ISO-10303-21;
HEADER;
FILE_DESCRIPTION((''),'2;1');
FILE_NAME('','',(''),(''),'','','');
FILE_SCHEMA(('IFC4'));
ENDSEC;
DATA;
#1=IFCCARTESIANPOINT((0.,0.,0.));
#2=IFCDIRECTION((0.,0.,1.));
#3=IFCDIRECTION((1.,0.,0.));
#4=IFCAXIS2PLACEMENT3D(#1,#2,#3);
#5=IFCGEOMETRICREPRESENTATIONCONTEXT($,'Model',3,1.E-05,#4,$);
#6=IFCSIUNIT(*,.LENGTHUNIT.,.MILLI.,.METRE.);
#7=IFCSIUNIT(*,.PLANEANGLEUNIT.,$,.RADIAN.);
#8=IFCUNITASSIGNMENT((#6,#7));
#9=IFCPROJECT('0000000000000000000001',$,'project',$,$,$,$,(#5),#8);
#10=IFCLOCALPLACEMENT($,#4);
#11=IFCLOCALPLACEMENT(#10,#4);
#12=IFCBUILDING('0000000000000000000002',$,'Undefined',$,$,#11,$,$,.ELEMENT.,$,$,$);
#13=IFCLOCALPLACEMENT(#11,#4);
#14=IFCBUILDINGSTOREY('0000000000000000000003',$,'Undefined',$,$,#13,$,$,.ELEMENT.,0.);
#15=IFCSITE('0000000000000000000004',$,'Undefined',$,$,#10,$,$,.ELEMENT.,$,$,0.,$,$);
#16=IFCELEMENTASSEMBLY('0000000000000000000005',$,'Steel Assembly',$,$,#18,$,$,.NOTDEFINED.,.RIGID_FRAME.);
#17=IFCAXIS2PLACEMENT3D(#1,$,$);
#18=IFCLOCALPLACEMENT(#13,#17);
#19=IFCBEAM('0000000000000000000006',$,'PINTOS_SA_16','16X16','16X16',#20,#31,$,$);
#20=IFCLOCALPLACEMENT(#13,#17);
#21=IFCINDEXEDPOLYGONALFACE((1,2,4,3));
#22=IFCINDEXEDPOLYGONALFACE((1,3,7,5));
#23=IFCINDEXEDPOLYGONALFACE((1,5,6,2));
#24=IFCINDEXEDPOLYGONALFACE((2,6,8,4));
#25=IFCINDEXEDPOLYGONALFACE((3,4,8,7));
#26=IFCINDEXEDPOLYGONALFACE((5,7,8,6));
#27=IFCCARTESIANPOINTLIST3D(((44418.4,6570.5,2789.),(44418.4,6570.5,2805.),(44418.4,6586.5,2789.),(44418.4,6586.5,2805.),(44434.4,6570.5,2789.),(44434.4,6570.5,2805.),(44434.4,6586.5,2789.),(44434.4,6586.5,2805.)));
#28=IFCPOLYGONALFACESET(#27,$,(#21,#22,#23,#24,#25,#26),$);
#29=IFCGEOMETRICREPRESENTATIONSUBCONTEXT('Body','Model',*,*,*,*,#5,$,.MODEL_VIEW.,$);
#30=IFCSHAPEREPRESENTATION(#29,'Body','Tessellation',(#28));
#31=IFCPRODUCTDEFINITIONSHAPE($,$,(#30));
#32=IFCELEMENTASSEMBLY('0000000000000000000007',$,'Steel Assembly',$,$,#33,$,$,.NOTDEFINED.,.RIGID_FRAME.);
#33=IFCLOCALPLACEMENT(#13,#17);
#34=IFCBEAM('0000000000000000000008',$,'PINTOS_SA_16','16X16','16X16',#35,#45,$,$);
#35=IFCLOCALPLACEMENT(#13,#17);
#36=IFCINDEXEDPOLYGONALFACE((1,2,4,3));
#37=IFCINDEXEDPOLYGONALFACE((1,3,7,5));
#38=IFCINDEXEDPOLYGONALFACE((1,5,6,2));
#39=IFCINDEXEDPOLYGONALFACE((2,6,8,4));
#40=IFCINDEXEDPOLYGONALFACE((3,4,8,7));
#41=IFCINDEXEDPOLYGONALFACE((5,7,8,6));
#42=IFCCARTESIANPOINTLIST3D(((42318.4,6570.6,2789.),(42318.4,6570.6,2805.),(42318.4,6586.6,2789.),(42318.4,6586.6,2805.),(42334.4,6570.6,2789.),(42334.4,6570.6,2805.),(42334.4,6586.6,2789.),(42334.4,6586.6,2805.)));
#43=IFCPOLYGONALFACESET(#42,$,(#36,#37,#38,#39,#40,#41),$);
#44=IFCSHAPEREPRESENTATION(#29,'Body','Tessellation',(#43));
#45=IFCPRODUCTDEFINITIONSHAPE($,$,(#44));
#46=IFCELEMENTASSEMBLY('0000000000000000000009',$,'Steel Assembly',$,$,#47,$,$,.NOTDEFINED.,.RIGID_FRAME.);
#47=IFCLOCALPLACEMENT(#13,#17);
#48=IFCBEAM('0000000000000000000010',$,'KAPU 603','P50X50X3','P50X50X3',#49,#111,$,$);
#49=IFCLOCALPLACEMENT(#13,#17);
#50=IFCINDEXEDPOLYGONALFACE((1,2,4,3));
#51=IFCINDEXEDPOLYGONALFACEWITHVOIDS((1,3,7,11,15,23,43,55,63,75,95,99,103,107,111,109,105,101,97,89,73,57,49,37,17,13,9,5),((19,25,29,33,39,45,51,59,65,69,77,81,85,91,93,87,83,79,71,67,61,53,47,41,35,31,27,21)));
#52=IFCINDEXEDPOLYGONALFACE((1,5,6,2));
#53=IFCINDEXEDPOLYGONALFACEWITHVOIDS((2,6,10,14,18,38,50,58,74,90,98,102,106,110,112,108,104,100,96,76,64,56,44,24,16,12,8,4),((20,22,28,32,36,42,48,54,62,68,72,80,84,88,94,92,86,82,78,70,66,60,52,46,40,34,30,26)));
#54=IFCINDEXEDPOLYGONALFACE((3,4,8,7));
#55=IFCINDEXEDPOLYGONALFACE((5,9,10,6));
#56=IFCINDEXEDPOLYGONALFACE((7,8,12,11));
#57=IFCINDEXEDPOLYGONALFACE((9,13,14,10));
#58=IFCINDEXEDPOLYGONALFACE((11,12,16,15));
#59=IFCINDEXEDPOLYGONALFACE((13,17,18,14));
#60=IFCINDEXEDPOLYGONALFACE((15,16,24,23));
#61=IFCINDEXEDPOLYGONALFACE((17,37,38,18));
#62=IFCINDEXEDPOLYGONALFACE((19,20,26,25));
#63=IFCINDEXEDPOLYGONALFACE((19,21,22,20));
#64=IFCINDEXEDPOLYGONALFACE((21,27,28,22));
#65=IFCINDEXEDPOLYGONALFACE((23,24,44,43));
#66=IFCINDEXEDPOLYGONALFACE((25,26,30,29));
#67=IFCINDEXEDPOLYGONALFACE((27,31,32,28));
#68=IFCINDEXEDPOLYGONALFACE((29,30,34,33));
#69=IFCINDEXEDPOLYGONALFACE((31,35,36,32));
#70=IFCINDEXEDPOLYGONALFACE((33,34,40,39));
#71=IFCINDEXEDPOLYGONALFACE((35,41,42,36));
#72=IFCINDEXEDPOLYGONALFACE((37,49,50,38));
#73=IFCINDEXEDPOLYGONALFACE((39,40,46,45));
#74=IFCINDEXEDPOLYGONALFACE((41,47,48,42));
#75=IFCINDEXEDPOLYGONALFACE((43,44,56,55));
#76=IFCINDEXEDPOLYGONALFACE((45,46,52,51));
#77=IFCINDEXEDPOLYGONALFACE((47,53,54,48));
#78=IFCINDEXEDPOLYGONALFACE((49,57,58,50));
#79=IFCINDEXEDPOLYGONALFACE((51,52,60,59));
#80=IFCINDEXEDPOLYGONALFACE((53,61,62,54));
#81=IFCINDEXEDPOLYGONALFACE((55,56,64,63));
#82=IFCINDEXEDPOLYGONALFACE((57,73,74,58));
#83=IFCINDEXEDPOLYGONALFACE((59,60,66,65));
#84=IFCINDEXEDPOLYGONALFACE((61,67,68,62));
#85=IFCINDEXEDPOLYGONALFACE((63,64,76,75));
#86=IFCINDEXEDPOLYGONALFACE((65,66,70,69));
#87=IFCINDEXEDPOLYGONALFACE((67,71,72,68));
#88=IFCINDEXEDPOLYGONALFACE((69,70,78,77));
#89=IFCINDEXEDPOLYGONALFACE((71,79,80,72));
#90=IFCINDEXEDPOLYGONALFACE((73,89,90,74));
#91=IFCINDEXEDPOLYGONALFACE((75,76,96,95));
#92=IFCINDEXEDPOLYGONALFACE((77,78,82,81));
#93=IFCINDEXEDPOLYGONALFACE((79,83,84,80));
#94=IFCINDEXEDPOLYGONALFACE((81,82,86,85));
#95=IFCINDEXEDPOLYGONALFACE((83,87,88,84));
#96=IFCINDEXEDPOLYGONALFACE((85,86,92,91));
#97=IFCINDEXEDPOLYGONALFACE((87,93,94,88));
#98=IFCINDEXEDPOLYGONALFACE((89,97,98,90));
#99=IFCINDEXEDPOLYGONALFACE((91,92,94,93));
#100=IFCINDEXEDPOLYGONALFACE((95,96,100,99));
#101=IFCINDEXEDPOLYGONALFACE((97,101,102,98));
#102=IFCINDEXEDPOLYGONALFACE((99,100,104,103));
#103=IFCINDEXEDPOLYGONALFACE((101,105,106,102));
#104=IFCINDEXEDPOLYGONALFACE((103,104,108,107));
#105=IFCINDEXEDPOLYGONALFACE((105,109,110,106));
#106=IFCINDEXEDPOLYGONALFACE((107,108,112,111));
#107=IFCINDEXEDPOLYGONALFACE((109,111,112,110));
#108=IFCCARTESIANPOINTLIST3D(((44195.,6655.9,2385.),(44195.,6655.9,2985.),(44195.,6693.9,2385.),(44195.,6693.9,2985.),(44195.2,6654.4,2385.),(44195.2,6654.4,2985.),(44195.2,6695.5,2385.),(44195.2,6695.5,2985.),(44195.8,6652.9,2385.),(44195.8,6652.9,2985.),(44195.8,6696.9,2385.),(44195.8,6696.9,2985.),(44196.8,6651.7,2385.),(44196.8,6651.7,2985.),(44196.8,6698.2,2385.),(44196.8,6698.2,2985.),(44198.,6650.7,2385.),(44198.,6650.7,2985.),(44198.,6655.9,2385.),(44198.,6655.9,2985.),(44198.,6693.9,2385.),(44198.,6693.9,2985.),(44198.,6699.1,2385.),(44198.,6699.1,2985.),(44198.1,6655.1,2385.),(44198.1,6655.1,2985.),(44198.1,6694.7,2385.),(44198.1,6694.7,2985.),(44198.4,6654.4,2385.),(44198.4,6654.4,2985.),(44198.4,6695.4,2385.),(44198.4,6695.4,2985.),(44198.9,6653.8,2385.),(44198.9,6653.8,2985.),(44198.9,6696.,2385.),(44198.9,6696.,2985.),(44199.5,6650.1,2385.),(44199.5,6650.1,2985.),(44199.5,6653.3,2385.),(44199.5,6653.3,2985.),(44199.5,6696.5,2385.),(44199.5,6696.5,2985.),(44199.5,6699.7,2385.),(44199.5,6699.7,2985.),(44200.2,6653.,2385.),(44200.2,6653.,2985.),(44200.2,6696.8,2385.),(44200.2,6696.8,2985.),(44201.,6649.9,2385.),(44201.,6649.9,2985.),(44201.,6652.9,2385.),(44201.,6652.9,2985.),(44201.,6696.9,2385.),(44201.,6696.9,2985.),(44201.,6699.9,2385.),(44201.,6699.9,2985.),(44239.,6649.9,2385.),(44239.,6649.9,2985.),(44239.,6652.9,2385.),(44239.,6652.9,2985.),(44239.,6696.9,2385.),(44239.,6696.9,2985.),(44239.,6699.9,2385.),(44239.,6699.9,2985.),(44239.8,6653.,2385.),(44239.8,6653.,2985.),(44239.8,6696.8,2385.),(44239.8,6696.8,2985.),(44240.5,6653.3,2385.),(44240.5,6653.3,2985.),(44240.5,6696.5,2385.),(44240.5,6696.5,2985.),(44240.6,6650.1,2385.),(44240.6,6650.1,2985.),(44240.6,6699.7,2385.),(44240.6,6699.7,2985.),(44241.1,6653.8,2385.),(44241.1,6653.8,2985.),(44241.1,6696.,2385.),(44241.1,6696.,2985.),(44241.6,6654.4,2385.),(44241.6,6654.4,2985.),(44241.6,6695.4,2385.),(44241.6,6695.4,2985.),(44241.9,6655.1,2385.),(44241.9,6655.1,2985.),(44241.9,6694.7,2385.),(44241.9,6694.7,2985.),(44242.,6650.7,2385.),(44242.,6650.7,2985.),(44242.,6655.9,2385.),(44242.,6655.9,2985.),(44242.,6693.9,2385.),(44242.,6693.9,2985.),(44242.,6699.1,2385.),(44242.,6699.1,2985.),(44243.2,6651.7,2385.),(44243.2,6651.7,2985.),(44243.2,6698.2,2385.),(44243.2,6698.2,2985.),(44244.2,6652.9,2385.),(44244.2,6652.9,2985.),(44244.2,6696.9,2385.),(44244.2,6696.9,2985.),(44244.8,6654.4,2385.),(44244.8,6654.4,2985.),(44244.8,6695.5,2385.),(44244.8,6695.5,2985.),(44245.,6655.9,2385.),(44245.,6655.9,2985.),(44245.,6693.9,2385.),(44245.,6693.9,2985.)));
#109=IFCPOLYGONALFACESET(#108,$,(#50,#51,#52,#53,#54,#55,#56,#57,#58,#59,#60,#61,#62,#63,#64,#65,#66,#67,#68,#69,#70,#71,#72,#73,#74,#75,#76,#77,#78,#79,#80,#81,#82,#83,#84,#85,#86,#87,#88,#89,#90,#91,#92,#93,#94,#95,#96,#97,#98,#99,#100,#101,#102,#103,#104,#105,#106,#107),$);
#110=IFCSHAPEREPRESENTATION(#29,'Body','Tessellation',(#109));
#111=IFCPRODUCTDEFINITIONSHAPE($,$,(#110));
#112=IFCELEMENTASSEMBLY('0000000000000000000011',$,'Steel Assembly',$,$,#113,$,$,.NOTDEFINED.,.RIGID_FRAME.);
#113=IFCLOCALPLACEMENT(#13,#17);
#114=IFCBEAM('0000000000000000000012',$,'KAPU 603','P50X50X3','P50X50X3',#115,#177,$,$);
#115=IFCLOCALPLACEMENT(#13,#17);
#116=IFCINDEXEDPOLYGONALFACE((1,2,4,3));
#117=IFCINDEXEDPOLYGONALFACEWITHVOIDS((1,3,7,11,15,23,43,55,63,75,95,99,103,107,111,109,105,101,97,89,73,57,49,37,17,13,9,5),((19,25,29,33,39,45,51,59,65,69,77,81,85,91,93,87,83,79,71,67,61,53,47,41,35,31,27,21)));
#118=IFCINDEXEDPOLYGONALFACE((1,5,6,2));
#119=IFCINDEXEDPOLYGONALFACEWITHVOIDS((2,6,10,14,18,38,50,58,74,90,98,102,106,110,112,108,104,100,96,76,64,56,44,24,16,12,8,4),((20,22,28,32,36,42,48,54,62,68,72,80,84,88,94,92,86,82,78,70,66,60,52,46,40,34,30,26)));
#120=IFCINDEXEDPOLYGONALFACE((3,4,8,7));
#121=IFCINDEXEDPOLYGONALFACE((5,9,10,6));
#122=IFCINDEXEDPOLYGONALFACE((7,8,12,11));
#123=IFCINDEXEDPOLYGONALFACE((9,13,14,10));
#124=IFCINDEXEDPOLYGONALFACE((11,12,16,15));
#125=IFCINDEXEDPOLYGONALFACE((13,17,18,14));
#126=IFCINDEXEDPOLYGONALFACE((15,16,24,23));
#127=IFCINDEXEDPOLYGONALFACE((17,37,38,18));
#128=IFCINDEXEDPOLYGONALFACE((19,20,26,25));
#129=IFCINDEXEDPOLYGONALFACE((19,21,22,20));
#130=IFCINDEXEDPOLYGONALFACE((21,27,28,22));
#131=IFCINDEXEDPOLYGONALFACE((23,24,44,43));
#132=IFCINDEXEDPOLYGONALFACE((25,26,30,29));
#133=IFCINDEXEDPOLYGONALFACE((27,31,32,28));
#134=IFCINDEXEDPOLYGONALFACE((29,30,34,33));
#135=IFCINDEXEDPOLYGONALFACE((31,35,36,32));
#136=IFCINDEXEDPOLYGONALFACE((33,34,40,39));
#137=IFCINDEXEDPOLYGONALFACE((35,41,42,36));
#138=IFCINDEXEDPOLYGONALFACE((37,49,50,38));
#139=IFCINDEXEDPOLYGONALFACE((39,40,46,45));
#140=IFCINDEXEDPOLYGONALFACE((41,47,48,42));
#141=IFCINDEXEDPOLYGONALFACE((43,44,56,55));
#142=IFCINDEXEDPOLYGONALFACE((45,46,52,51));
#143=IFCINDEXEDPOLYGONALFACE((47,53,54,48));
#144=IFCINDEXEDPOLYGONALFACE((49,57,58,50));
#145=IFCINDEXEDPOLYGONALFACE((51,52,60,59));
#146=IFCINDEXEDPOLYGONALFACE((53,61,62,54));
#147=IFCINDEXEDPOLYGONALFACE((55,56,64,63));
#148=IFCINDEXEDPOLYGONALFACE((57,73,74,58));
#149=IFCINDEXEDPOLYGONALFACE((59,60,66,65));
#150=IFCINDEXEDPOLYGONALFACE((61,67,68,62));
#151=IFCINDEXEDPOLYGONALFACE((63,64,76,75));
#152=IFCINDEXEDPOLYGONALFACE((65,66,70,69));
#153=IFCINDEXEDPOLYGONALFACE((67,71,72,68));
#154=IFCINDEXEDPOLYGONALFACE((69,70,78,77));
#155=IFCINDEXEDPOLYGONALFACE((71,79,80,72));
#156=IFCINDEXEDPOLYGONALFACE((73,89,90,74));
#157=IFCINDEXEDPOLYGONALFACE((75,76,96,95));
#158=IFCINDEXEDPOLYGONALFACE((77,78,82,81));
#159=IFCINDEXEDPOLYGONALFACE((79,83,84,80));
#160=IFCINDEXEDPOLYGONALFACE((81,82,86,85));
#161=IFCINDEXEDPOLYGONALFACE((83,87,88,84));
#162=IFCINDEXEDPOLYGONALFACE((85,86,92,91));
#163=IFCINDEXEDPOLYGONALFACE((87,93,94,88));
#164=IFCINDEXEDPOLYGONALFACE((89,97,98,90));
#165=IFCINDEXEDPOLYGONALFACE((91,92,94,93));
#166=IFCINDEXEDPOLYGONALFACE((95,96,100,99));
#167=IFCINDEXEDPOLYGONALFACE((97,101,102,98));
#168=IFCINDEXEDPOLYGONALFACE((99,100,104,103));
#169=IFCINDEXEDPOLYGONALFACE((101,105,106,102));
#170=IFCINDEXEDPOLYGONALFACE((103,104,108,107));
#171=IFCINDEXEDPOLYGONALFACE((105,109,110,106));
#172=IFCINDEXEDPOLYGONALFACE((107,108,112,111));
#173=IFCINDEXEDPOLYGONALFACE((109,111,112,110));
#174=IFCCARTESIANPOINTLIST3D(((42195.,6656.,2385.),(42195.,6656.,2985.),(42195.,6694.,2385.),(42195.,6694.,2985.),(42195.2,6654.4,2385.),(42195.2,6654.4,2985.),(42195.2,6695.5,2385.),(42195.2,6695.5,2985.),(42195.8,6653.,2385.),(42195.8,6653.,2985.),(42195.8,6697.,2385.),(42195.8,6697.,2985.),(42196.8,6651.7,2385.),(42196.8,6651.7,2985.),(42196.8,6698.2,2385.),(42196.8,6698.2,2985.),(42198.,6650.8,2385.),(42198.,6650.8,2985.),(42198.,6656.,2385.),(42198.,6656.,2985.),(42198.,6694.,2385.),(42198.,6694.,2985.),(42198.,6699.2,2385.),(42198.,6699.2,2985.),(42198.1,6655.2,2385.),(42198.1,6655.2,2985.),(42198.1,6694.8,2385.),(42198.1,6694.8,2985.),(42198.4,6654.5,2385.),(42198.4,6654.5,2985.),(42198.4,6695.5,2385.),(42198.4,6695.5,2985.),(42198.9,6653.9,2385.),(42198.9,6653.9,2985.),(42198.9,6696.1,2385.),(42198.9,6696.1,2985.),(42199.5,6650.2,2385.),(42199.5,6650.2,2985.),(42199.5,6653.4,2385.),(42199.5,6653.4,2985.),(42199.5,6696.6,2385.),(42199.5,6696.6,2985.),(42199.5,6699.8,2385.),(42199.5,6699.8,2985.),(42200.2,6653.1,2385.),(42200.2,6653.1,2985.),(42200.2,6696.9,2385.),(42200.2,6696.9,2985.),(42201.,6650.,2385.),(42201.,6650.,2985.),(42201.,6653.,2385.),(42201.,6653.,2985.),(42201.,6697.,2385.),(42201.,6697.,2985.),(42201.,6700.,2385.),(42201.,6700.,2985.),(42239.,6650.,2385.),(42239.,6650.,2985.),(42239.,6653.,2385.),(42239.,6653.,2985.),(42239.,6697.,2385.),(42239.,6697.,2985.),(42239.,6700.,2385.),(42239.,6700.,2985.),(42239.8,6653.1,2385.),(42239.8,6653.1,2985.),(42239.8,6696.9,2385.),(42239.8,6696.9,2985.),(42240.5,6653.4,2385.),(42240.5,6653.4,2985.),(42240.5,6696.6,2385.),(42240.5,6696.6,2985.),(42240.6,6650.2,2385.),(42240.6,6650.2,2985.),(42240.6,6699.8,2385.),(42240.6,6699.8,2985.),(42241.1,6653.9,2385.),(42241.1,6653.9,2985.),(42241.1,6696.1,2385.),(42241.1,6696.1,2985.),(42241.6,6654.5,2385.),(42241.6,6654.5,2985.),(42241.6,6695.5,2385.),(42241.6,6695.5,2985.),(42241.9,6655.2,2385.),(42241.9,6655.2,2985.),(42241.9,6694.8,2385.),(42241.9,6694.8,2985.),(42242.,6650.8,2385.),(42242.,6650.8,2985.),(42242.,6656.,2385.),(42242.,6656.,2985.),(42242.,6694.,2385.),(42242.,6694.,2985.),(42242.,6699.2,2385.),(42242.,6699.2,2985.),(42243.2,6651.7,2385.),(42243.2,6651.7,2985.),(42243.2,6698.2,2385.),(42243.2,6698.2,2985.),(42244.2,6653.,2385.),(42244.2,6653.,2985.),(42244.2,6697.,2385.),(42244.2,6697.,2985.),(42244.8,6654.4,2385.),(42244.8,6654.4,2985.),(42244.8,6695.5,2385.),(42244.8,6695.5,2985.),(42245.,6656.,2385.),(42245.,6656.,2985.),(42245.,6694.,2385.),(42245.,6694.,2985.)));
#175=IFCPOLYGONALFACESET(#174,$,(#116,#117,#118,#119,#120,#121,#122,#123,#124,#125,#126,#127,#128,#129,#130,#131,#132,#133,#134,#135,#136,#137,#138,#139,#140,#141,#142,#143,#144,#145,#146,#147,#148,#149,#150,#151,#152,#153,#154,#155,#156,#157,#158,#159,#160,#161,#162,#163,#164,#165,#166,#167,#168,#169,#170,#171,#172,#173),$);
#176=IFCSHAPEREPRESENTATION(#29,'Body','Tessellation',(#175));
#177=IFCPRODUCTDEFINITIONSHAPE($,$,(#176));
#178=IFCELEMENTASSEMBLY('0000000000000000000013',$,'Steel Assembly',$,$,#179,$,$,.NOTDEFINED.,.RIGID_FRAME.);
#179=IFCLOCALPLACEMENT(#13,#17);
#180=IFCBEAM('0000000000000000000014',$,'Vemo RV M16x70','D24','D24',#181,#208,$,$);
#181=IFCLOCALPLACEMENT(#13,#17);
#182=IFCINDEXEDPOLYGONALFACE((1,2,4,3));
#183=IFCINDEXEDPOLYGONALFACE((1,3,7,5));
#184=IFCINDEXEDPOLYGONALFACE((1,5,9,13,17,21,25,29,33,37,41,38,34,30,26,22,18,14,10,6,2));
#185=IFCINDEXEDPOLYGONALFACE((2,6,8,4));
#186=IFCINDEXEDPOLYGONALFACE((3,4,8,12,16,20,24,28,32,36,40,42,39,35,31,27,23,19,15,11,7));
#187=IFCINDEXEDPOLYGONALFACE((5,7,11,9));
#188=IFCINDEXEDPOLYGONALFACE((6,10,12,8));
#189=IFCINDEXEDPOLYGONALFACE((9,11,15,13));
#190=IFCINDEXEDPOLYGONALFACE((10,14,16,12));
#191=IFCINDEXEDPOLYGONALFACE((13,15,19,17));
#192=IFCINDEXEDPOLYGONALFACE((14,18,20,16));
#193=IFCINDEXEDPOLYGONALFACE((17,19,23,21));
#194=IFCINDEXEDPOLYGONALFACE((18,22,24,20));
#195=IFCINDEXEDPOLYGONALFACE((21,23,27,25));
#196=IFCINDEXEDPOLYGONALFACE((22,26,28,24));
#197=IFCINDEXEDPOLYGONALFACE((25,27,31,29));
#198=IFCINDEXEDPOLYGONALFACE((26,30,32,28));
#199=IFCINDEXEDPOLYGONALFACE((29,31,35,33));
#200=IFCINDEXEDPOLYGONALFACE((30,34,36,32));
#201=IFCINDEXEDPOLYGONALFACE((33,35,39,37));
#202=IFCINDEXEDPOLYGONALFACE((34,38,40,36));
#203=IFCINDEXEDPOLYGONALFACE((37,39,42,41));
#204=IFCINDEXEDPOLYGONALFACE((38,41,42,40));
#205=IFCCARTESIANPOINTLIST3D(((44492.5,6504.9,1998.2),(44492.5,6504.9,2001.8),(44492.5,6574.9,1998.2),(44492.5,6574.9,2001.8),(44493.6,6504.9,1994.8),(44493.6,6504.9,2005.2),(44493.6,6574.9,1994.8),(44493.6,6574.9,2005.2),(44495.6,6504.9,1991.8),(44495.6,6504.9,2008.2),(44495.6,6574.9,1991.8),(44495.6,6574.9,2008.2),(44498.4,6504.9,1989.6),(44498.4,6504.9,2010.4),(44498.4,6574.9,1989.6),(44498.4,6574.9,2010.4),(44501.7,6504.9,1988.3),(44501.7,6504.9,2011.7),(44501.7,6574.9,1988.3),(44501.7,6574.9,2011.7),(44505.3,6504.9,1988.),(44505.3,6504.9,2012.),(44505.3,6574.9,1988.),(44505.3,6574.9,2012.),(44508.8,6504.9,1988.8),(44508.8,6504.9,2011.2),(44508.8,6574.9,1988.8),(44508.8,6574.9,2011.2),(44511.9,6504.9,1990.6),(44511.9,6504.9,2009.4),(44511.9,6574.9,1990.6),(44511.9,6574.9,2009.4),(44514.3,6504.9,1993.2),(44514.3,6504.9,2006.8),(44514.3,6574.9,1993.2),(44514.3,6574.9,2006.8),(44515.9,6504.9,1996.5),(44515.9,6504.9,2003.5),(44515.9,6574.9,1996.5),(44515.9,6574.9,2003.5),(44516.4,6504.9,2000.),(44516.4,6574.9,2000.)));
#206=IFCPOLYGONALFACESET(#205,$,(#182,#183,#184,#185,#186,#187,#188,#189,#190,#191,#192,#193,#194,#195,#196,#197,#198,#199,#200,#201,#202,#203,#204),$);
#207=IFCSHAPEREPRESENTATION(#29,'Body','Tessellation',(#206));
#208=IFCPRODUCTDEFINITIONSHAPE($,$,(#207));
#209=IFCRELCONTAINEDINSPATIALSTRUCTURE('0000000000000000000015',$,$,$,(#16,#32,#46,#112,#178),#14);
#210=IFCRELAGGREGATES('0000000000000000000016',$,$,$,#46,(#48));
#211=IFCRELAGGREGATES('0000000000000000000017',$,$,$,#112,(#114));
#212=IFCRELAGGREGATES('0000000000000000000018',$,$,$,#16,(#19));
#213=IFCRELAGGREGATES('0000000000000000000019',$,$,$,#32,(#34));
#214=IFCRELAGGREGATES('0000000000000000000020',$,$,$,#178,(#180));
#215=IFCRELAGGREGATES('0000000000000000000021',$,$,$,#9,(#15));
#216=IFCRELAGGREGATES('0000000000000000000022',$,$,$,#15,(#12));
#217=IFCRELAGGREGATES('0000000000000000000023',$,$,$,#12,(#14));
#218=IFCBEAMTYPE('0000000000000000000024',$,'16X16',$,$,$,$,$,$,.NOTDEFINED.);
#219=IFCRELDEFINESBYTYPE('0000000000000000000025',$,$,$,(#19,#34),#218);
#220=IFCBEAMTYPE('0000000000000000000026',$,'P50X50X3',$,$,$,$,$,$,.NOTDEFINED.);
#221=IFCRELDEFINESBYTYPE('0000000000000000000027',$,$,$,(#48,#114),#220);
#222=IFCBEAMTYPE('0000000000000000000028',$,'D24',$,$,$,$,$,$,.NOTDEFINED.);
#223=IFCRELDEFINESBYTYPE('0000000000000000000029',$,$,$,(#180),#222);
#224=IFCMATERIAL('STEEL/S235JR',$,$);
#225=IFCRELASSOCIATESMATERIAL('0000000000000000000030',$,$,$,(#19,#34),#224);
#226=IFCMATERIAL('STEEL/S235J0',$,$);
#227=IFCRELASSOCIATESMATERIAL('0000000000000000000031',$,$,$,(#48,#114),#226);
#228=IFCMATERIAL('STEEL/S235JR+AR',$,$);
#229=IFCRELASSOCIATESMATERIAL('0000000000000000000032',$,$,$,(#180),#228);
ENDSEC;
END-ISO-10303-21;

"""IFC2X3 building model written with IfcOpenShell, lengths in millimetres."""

from ifc_helpers import new_model, si_unit, frame, origin_with_axes, origin_2d_with_axis, place, context, subcontext, project, spatial, rectangle, hollow_rectangle, circle, extrude, material, type_object, element, aggregate, save


model = new_model("IFC2X3")

# Units and contexts
model_context = context("Model", 3, precision=1e-05, world=origin_with_axes())
body_context = subcontext(model_context, "Body", "Model", "MODEL_VIEW")
ifc_project = project(units=[si_unit("LENGTHUNIT", "METRE", prefix="MILLI"), si_unit("PLANEANGLEUNIT", "RADIAN")], contexts=[model_context])

# Site, building, storey
site_placement = place(None, origin_with_axes())
site = spatial("IfcSite", under=ifc_project, at=site_placement, Name="Undefined", CompositionType="ELEMENT", RefElevation=0.0)
building_placement = place(site_placement, origin_with_axes())
building = spatial("IfcBuilding", under=site, at=building_placement, Name="Undefined", CompositionType="ELEMENT")
storey_placement = place(building_placement, origin_with_axes())
storey = spatial("IfcBuildingStorey", under=building, at=storey_placement, Name="Undefined", CompositionType="ELEMENT", Elevation=0.0)

# Element assemblies, beams
assembly_1_placement = place(storey_placement, origin_with_axes())
assembly_1 = element("IfcElementAssembly", 1, at=assembly_1_placement, inside=storey, Name="Steel Assembly", AssemblyPlace="NOTDEFINED", PredefinedType="RIGID_FRAME")
ifc_material_1 = material(Name="STEEL/S235JR")
beam_type_1 = type_object("IfcBeamType", Name="16X16", PredefinedType="NOTDEFINED")
beam_1_placement = place(assembly_1_placement, frame((44434.4, 6578.5, 2797.0), z_axis=(0.0, 0.0, 1.0), x_axis=(-1.0, 0.00003, 0.0)))
beam_1 = element("IfcBeam", 2, at=beam_1_placement, type_object=beam_type_1, material=ifc_material_1, Name="PINTOS_SA_16", Description="16X16", ObjectType="16X16", context=body_context, shape_type="SweptSolid", body=[
    extrude(rectangle(XDim=16.0, YDim=16.0, at=origin_2d_with_axis()), frame((16.0, 0.0, 0.0), z_axis=(-1.0, 0.0, 0.0), x_axis=(0.0, -1.0, 0.0)), (0.0, 0.0, 1.0), 16.0),
])
assembly_2_placement = place(storey_placement, origin_with_axes())
assembly_2 = element("IfcElementAssembly", 3, at=assembly_2_placement, inside=storey, Name="Steel Assembly", AssemblyPlace="NOTDEFINED", PredefinedType="RIGID_FRAME")
beam_2_placement = place(assembly_2_placement, frame((42318.4, 6578.6, 2797.0), z_axis=(0.0, 0.0, 1.0), x_axis=(1.0, -0.00003, 0.0)))
beam_2 = element("IfcBeam", 4, at=beam_2_placement, type_object=beam_type_1, material=ifc_material_1, Name="PINTOS_SA_16", Description="16X16", ObjectType="16X16", context=body_context, shape_type="SweptSolid", body=[
    extrude(rectangle(XDim=16.0, YDim=16.0, at=origin_2d_with_axis()), frame((16.0, 0.0, 0.0), z_axis=(-1.0, 0.0, 0.0), x_axis=(0.0, -1.0, 0.0)), (0.0, 0.0, 1.0), 16.0),
])
assembly_3_placement = place(storey_placement, origin_with_axes())
assembly_3 = element("IfcElementAssembly", 5, at=assembly_3_placement, inside=storey, Name="Steel Assembly", AssemblyPlace="NOTDEFINED", PredefinedType="RIGID_FRAME")
ifc_material_2 = material(Name="STEEL/S235J0")
beam_type_2 = type_object("IfcBeamType", Name="P50X50X3", PredefinedType="NOTDEFINED")
beam_3_placement = place(assembly_3_placement, frame((44220.0, 6674.9, 2985.0), z_axis=(1.0, -0.00003, 0.0), x_axis=(0.0, 0.0, -1.0)))
beam_3 = element("IfcBeam", 6, at=beam_3_placement, type_object=beam_type_2, material=ifc_material_2, Name="KAPU 603", Description="P50X50X3", ObjectType="P50X50X3", context=body_context, shape_type="SweptSolid", body=[
    extrude(hollow_rectangle(XDim=50.0, YDim=50.0, WallThickness=3.0, InnerFilletRadius=3.0, OuterFilletRadius=6.0, at=origin_2d_with_axis()), frame((600.0, 0.0, 0.0), z_axis=(-1.0, 0.0, 0.0), x_axis=(0.0, -1.0, 0.0)), (0.0, 0.0, 1.0), 600.0),
])
aggregate(assembly_3, [beam_3])
assembly_4_placement = place(storey_placement, origin_with_axes())
assembly_4 = element("IfcElementAssembly", 7, at=assembly_4_placement, inside=storey, Name="Steel Assembly", AssemblyPlace="NOTDEFINED", PredefinedType="RIGID_FRAME")
beam_4_placement = place(assembly_4_placement, frame((42220.0, 6675.0, 2985.0), z_axis=(1.0, -0.00003, 0.0), x_axis=(0.0, 0.0, -1.0)))
beam_4 = element("IfcBeam", 8, at=beam_4_placement, type_object=beam_type_2, material=ifc_material_2, Name="KAPU 603", Description="P50X50X3", ObjectType="P50X50X3", context=body_context, shape_type="SweptSolid", body=[
    extrude(hollow_rectangle(XDim=50.0, YDim=50.0, WallThickness=3.0, InnerFilletRadius=3.0, OuterFilletRadius=6.0, at=origin_2d_with_axis()), frame((600.0, 0.0, 0.0), z_axis=(-1.0, 0.0, 0.0), x_axis=(0.0, -1.0, 0.0)), (0.0, 0.0, 1.0), 600.0),
])
aggregate(assembly_4, [beam_4])
assembly_5_placement = place(storey_placement, origin_with_axes())
assembly_5 = element("IfcElementAssembly", 9, at=assembly_5_placement, inside=storey, Name="Steel Assembly", AssemblyPlace="NOTDEFINED", PredefinedType="RIGID_FRAME")
ifc_material_3 = material(Name="STEEL/S235JR+AR")
beam_type_3 = type_object("IfcBeamType", Name="D24", PredefinedType="NOTDEFINED")
beam_5_placement = place(assembly_5_placement, frame((44504.4, 6504.9, 2000.0), z_axis=(0.0, 0.0, 1.0), x_axis=(0.00003, 1.0, 0.0)))
beam_5 = element("IfcBeam", 10, at=beam_5_placement, type_object=beam_type_3, material=ifc_material_3, Name="Vemo RV M16x70", Description="D24", ObjectType="D24", context=body_context, shape_type="SweptSolid", body=[
    extrude(circle(Radius=12.0, at=origin_2d_with_axis()), frame((70.0, 0.0, 0.0), z_axis=(-1.0, 0.0, 0.0), x_axis=(0.0, -1.0, 0.0)), (0.0, 0.0, 1.0), 70.0),
])

aggregate(assembly_1, [beam_1])
aggregate(assembly_2, [beam_2])

aggregate(assembly_5, [beam_5])

save(model, "model.ifc")
